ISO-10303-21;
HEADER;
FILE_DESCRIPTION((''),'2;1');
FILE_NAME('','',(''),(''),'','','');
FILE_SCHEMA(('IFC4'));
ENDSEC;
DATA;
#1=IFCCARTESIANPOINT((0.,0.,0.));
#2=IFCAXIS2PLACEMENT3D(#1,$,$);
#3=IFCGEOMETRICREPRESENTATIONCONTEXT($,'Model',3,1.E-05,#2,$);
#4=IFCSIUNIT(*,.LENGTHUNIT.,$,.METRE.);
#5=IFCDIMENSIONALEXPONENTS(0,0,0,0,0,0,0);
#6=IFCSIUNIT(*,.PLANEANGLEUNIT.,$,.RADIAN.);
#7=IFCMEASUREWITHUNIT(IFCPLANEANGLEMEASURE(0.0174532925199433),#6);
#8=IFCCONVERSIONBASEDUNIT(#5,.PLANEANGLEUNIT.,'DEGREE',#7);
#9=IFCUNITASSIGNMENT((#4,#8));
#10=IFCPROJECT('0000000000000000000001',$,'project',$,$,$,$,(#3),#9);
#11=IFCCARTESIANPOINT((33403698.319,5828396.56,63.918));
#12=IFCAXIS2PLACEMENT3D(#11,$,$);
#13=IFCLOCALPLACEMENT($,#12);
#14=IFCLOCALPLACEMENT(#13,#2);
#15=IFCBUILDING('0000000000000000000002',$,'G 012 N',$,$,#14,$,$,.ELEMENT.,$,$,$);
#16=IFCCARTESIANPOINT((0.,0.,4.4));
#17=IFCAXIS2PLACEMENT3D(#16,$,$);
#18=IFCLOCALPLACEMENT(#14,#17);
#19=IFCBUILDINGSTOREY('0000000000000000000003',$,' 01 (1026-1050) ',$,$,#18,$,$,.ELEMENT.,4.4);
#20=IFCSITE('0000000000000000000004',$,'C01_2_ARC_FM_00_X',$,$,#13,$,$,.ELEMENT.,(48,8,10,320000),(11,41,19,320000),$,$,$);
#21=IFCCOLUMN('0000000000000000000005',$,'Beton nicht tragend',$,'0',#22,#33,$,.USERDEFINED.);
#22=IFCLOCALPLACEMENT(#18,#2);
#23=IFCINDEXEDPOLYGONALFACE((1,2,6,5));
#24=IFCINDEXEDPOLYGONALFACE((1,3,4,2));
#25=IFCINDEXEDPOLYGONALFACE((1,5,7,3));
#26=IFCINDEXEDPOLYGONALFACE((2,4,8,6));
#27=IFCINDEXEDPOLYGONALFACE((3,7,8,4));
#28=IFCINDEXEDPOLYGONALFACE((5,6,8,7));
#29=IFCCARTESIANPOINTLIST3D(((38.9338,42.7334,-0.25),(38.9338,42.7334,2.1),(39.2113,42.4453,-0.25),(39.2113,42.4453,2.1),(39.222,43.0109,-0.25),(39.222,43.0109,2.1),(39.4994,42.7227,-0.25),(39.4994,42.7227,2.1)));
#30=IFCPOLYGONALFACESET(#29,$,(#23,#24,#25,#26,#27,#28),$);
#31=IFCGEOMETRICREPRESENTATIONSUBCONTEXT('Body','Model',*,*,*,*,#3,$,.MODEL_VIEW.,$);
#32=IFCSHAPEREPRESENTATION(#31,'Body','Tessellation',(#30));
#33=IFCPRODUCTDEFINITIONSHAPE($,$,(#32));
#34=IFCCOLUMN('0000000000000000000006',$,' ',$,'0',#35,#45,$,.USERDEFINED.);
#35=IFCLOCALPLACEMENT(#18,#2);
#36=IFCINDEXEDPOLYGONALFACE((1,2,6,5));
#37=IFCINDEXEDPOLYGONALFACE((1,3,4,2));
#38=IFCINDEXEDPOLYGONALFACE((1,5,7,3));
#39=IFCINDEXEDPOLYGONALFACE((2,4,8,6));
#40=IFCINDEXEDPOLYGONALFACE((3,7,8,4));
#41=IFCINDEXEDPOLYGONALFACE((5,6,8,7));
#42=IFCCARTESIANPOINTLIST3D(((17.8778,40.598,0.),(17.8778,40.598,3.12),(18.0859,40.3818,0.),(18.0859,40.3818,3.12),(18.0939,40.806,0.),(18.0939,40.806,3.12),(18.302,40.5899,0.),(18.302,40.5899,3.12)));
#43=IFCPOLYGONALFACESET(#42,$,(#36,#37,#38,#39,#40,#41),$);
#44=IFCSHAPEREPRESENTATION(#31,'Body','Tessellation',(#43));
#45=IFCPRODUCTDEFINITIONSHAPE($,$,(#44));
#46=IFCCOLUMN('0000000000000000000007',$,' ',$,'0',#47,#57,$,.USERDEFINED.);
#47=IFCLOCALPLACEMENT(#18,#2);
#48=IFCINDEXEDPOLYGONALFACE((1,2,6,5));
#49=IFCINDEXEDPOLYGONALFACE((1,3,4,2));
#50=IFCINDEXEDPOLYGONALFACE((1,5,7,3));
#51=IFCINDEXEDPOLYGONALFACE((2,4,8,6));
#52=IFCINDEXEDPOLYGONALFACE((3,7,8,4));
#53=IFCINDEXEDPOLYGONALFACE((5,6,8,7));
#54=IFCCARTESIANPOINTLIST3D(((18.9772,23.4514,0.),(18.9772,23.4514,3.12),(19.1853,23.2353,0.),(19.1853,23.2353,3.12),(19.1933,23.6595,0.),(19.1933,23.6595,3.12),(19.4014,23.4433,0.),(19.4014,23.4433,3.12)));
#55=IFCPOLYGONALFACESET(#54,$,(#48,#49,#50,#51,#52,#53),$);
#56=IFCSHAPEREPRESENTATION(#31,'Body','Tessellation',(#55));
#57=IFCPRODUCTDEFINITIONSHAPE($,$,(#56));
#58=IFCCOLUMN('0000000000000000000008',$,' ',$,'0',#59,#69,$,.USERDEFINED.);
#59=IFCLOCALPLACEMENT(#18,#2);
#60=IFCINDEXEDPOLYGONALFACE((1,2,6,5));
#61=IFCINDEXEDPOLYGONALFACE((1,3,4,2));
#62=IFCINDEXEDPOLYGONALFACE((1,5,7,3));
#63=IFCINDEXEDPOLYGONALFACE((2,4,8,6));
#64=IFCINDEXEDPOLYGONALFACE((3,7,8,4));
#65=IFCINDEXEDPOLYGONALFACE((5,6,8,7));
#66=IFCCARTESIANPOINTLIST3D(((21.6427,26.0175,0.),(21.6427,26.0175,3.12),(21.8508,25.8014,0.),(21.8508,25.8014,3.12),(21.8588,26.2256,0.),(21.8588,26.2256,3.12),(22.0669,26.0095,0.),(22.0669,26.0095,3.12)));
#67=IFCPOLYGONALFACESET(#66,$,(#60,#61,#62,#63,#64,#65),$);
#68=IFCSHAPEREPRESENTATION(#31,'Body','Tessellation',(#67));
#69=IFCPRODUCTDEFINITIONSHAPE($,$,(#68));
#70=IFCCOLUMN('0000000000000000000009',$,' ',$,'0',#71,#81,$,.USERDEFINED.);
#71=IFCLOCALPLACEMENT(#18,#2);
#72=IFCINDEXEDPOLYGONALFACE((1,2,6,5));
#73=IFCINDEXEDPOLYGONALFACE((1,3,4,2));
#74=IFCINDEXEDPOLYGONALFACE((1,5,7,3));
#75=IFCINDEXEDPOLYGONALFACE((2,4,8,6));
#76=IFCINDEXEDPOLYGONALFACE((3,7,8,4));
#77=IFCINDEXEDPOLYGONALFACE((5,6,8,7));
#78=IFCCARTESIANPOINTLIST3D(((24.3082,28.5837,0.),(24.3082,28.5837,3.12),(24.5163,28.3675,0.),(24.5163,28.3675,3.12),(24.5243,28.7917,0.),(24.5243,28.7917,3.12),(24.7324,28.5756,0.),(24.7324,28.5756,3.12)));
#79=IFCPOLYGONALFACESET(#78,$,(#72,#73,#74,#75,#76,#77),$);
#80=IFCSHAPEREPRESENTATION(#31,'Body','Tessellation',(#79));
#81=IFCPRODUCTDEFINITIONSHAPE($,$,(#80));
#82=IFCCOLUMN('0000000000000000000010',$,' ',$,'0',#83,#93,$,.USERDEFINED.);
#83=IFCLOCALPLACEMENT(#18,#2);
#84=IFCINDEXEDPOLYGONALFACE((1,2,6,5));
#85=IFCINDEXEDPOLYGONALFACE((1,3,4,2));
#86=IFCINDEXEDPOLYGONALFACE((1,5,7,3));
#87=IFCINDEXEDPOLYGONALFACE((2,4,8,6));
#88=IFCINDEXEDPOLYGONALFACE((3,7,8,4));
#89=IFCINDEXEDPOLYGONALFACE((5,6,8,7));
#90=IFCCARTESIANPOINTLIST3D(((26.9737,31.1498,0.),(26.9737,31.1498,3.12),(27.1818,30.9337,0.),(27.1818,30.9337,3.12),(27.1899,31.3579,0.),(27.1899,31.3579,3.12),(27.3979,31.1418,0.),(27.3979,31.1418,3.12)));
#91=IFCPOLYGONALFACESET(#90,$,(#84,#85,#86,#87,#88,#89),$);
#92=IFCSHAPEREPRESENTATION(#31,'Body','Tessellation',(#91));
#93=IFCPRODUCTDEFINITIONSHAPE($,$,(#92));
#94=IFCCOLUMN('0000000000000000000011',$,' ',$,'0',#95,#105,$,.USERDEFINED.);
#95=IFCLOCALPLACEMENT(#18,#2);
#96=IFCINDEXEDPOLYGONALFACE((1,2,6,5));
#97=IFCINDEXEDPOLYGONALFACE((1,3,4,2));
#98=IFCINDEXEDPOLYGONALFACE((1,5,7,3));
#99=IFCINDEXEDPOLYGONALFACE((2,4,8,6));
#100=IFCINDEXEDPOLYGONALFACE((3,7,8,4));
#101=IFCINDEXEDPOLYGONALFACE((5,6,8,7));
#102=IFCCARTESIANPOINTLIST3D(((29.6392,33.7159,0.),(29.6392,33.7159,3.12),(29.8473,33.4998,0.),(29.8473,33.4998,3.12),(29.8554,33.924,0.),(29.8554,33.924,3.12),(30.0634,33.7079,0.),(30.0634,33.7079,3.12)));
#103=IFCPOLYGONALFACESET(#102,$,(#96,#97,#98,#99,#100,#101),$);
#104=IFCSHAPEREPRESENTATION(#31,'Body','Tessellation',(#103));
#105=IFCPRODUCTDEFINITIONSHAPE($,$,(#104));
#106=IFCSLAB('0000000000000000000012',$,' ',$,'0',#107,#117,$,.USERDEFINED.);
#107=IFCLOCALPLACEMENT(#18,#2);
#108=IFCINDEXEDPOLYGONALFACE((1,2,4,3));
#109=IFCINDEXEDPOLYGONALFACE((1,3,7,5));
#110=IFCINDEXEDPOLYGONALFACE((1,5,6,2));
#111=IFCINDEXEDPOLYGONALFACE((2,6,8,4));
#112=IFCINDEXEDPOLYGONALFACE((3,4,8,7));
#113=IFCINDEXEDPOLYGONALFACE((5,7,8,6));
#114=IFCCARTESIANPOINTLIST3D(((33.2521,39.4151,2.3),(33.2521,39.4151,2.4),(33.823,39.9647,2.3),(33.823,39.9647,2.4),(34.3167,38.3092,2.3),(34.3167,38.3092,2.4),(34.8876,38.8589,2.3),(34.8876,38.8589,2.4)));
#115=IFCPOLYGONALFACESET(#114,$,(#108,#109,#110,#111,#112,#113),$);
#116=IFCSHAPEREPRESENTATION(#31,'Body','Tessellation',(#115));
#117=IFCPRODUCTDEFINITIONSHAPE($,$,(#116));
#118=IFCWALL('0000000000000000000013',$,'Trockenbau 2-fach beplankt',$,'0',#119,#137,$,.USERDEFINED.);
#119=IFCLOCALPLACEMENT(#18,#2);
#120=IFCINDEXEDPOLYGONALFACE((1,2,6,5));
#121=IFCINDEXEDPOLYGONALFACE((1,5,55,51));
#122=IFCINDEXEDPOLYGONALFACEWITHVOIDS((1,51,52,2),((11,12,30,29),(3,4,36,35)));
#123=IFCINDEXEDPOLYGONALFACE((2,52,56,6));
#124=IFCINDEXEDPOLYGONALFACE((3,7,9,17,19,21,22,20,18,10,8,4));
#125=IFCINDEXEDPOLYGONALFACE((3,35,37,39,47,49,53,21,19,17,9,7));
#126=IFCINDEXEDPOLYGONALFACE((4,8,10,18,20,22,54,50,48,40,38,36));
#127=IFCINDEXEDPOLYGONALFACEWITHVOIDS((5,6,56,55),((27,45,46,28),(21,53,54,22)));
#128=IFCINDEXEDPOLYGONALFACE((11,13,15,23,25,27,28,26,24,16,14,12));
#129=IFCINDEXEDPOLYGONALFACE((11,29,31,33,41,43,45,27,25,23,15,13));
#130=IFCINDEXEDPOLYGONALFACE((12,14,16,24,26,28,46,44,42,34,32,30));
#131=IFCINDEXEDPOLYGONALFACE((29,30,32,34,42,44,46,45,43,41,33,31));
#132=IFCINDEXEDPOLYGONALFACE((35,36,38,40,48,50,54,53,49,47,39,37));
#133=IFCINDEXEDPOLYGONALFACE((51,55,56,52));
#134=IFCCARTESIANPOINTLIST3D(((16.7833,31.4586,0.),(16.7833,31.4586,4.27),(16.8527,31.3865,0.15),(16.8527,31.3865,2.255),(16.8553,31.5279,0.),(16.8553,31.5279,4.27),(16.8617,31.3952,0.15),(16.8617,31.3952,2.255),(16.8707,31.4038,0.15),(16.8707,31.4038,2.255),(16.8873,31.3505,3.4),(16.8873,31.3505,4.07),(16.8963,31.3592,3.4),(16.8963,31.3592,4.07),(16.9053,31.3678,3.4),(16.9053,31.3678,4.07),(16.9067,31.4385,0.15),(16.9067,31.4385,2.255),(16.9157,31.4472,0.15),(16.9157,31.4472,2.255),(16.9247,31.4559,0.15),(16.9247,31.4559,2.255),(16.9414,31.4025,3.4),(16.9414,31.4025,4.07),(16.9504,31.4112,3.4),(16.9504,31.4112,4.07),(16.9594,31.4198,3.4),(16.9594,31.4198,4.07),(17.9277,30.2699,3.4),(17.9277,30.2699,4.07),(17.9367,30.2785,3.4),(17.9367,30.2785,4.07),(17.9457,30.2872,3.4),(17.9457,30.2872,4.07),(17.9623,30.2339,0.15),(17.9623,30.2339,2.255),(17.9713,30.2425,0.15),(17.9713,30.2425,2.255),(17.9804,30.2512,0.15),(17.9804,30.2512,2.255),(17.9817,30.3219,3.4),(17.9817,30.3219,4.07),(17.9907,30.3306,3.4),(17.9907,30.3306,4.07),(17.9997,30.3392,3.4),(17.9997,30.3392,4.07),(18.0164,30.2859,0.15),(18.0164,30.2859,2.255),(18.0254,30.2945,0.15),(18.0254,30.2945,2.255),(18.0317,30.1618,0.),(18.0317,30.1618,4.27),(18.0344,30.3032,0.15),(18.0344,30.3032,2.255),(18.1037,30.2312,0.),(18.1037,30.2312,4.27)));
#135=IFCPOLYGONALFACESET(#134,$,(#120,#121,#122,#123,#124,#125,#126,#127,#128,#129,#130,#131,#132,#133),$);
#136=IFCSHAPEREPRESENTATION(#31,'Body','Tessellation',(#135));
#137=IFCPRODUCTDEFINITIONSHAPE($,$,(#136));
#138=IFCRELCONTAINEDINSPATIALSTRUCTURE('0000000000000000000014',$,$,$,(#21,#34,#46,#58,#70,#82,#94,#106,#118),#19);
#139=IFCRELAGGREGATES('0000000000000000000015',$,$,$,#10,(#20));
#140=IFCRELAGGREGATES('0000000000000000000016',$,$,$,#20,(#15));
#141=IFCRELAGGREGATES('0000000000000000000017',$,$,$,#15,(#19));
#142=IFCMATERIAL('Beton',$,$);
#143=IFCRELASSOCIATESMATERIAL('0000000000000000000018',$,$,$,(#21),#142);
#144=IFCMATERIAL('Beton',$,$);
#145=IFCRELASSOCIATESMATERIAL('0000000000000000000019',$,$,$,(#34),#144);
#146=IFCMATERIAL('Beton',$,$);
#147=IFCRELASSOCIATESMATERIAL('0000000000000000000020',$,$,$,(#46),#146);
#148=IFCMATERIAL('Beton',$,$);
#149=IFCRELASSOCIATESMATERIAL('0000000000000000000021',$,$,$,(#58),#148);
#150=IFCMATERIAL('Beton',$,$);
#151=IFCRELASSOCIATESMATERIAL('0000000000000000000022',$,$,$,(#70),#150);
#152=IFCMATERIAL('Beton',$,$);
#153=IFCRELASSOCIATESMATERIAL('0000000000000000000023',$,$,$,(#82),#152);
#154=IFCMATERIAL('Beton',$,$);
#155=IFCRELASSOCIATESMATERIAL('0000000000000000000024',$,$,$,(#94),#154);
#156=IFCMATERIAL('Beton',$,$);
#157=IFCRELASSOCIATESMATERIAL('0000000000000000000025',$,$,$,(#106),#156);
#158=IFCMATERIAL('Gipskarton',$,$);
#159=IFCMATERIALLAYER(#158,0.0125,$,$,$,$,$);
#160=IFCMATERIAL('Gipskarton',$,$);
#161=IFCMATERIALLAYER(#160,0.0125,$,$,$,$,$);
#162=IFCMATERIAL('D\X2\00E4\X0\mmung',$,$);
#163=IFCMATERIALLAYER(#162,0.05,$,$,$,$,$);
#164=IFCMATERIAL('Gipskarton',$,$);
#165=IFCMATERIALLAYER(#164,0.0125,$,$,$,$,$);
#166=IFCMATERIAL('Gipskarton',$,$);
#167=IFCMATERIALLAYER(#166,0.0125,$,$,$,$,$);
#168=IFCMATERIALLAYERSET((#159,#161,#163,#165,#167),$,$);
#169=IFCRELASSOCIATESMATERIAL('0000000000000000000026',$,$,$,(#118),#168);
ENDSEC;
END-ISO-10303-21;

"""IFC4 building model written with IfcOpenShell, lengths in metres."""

from ifc_helpers import new_model, entity, si_unit, converted_unit, frame, frame_2d, origin, origin_with_axes, place, context, subcontext, project, spatial, polyline, rectangle, outline, extrude, material, layer, layer_set, layer_usage, element, save


model = new_model("IFC4")

# Units and contexts
model_context = context("Model", 3, precision=1e-05, world=origin())
body_context = subcontext(model_context, "Body", "Model", "MODEL_VIEW")
ifc_project = project(units=[si_unit("LENGTHUNIT", "METRE"), converted_unit("PLANEANGLEUNIT", "DEGREE", entity("IfcPlaneAngleMeasure", 0.0174532925199433), si_unit("PLANEANGLEUNIT", "RADIAN"), dimensions=[0, 0, 0, 0, 0, 0, 0])], contexts=[model_context])

# Site, building, storey
site_placement = place(None, frame((33403698.319, 5828396.56, 63.918)))
site = spatial("IfcSite", under=ifc_project, at=site_placement, Name="C01_2_ARC_FM_00_X", CompositionType="ELEMENT", RefLatitude=(48, 8, 10, 320000), RefLongitude=(11, 41, 19, 320000))
building_placement = place(site_placement, origin())
building = spatial("IfcBuilding", under=site, at=building_placement, Name="G 012 N", CompositionType="ELEMENT")
storey_placement = place(building_placement, frame((0.0, 0.0, 4.4)))
storey = spatial("IfcBuildingStorey", under=building, at=storey_placement, Name=" 01 (1026-1050) ", CompositionType="ELEMENT", Elevation=4.4)

# Columns
ifc_material_1 = material(Name="Beton")
column_1_placement = place(storey_placement, frame((39.2113, 42.4453, -0.25)))
element("IfcColumn", 1, at=column_1_placement, inside=storey, material=ifc_material_1, Name="Beton nicht tragend", ObjectType="0", PredefinedType="USERDEFINED", context=body_context, shape_type="SweptSolid", body=[
    extrude(rectangle(XDim=0.4, YDim=0.4, at=frame_2d((0.0054, 0.2828), x_axis=(0.720408, 0.693551))), origin_with_axes(), (0.0, 0.0, 1.0), 2.35),
])
ifc_material_2 = material(Name="Beton")
column_2_placement = place(storey_placement, frame((18.0859, 40.3818, 0.0)))
element("IfcColumn", 2, at=column_2_placement, inside=storey, material=ifc_material_2, Name=" ", ObjectType="0", PredefinedType="USERDEFINED", context=body_context, shape_type="SweptSolid", body=[
    extrude(rectangle(XDim=0.3, YDim=0.3, at=frame_2d((0.004, 0.2121), x_axis=(0.720408, 0.693551))), origin_with_axes(), (0.0, 0.0, 1.0), 3.12),
])
ifc_material_3 = material(Name="Beton")
column_3_placement = place(storey_placement, frame((19.1853, 23.2353, 0.0)))
element("IfcColumn", 3, at=column_3_placement, inside=storey, material=ifc_material_3, Name=" ", ObjectType="0", PredefinedType="USERDEFINED", context=body_context, shape_type="SweptSolid", body=[
    extrude(rectangle(XDim=0.3, YDim=0.3, at=frame_2d((0.004, 0.2121), x_axis=(0.720408, 0.693551))), origin_with_axes(), (0.0, 0.0, 1.0), 3.12),
])
ifc_material_4 = material(Name="Beton")
column_4_placement = place(storey_placement, frame((21.8508, 25.8014, 0.0)))
element("IfcColumn", 4, at=column_4_placement, inside=storey, material=ifc_material_4, Name=" ", ObjectType="0", PredefinedType="USERDEFINED", context=body_context, shape_type="SweptSolid", body=[
    extrude(rectangle(XDim=0.3, YDim=0.3, at=frame_2d((0.004, 0.2121), x_axis=(0.720408, 0.693551))), origin_with_axes(), (0.0, 0.0, 1.0), 3.12),
])
ifc_material_5 = material(Name="Beton")
column_5_placement = place(storey_placement, frame((24.5163, 28.3675, 0.0)))
element("IfcColumn", 5, at=column_5_placement, inside=storey, material=ifc_material_5, Name=" ", ObjectType="0", PredefinedType="USERDEFINED", context=body_context, shape_type="SweptSolid", body=[
    extrude(rectangle(XDim=0.3, YDim=0.3, at=frame_2d((0.004, 0.2121), x_axis=(0.720408, 0.693551))), origin_with_axes(), (0.0, 0.0, 1.0), 3.12),
])
ifc_material_6 = material(Name="Beton")
column_6_placement = place(storey_placement, frame((27.1818, 30.9337, 0.0)))
element("IfcColumn", 6, at=column_6_placement, inside=storey, material=ifc_material_6, Name=" ", ObjectType="0", PredefinedType="USERDEFINED", context=body_context, shape_type="SweptSolid", body=[
    extrude(rectangle(XDim=0.3, YDim=0.3, at=frame_2d((0.004, 0.2121), x_axis=(0.720408, 0.693551))), origin_with_axes(), (0.0, 0.0, 1.0), 3.12),
])
ifc_material_7 = material(Name="Beton")
column_7_placement = place(storey_placement, frame((29.8473, 33.4998, 0.0)))
element("IfcColumn", 7, at=column_7_placement, inside=storey, material=ifc_material_7, Name=" ", ObjectType="0", PredefinedType="USERDEFINED", context=body_context, shape_type="SweptSolid", body=[
    extrude(rectangle(XDim=0.3, YDim=0.3, at=frame_2d((0.004, 0.2121), x_axis=(0.720408, 0.693551))), origin_with_axes(), (0.0, 0.0, 1.0), 3.12),
])

# Slab
ifc_material_8 = material(Name="Beton")
slab_placement = place(storey_placement, frame((33.2521, 38.3092, 2.3)))
element("IfcSlab", 8, at=slab_placement, inside=storey, material=ifc_material_8, Name=" ", ObjectType="0", PredefinedType="USERDEFINED", context=body_context, shape_type="SweptSolid", body=[
    extrude(rectangle(XDim=0.7925, YDim=1.535, at=frame_2d((0.2468, -0.8277), x_axis=(-0.720408, -0.693551))), frame((0.5709, 1.6555, 0.0), z_axis=(0.0, 0.0, 1.0), x_axis=(1.0, 0.0, 0.0)), (0.0, 0.0, 1.0), 0.1),
])

# Wall, openings
ifc_material_9 = material(Name="Gipskarton")
ifc_layer_1 = layer(ifc_material_9, 0.0125)
ifc_material_10 = material(Name="Gipskarton")
ifc_layer_2 = layer(ifc_material_10, 0.0125)
ifc_material_11 = material(Name="Dämmung")
ifc_layer_3 = layer(ifc_material_11, 0.05)
ifc_material_12 = material(Name="Gipskarton")
ifc_layer_4 = layer(ifc_material_12, 0.0125)
ifc_material_13 = material(Name="Gipskarton")
ifc_layer_5 = layer(ifc_material_13, 0.0125)
ifc_layer_set_1 = layer_set([ifc_layer_1, ifc_layer_2, ifc_layer_3, ifc_layer_4, ifc_layer_5])
ifc_layer_usage_1 = layer_usage(ifc_layer_set_1, "AXIS2", "POSITIVE", 0.0)
wall_1_placement = place(storey_placement, frame((18.1037, 30.2312, 0.0), z_axis=(0.0, 0.0, 1.0), x_axis=(-0.693551, 0.720408, 0.0)))
wall_1 = element("IfcWall", 9, at=wall_1_placement, inside=storey, material=ifc_layer_usage_1, Name="Trockenbau 2-fach beplankt", ObjectType="0", PredefinedType="USERDEFINED", context=body_context, shape_type="SweptSolid", body=[
    extrude(rectangle(XDim=1.8, YDim=0.1, at=frame_2d((0.9, 0.05), x_axis=(1.0, 0.0))), origin_with_axes(), (0.0, 0.0, 1.0), 4.27),
])
opening_1_placement = place(wall_1_placement, frame((0.1, 0.0, 0.15), z_axis=(0.0, 1.0, 0.0), x_axis=(0.0, 0.0, 1.0)))
element("IfcOpeningElement", 10, at=opening_1_placement, cuts=wall_1, ObjectType="0", PredefinedType="USERDEFINED", context=body_context, shape_type="SweptSolid", body=[
    extrude(outline(polyline([(0.0, 1.6), (2.105, 1.6), (2.105, 0.0), (0.0, 0.0), (0.0, 1.6)])), origin_with_axes(), (0.0, 0.0, 1.0), 0.0125),
    extrude(outline(polyline([(0.0, 1.6), (2.105, 1.6), (2.105, 0.0), (0.0, 0.0), (0.0, 1.6)])), frame((0.0, 0.0, 0.0125), z_axis=(0.0, 0.0, 1.0), x_axis=(1.0, 0.0, 0.0)), (0.0, 0.0, 1.0), 0.0125),
    extrude(outline(polyline([(0.0, 1.6), (2.105, 1.6), (2.105, 0.0), (0.0, 0.0), (0.0, 1.6)])), frame((0.0, 0.0, 0.025), z_axis=(0.0, 0.0, 1.0), x_axis=(1.0, 0.0, 0.0)), (0.0, 0.0, 1.0), 0.05),
    extrude(outline(polyline([(0.0, 1.6), (2.105, 1.6), (2.105, 0.0), (0.0, 0.0), (0.0, 1.6)])), frame((0.0, 0.0, 0.075), z_axis=(0.0, 0.0, 1.0), x_axis=(1.0, 0.0, 0.0)), (0.0, 0.0, 1.0), 0.0125),
    extrude(outline(polyline([(0.0, 1.6), (2.105, 1.6), (2.105, 0.0), (0.0, 0.0), (0.0, 1.6)])), frame((0.0, 0.0, 0.0875), z_axis=(0.0, 0.0, 1.0), x_axis=(1.0, 0.0, 0.0)), (0.0, 0.0, 1.0), 0.0125),
])
opening_2_placement = place(wall_1_placement, frame((0.15, 0.0, 3.4), z_axis=(0.0, 1.0, 0.0), x_axis=(0.0, 0.0, 1.0)))
element("IfcOpeningElement", 11, at=opening_2_placement, cuts=wall_1, ObjectType="0", PredefinedType="USERDEFINED", context=body_context, shape_type="SweptSolid", body=[
    extrude(outline(polyline([(0.0, 1.5), (0.67, 1.5), (0.67, 0.0), (0.0, 0.0), (0.0, 1.5)])), origin_with_axes(), (0.0, 0.0, 1.0), 0.0125),
    extrude(outline(polyline([(0.0, 1.5), (0.67, 1.5), (0.67, 0.0), (0.0, 0.0), (0.0, 1.5)])), frame((0.0, 0.0, 0.0125), z_axis=(0.0, 0.0, 1.0), x_axis=(1.0, 0.0, 0.0)), (0.0, 0.0, 1.0), 0.0125),
    extrude(outline(polyline([(0.0, 1.5), (0.67, 1.5), (0.67, 0.0), (0.0, 0.0), (0.0, 1.5)])), frame((0.0, 0.0, 0.025), z_axis=(0.0, 0.0, 1.0), x_axis=(1.0, 0.0, 0.0)), (0.0, 0.0, 1.0), 0.05),
    extrude(outline(polyline([(0.0, 1.5), (0.67, 1.5), (0.67, 0.0), (0.0, 0.0), (0.0, 1.5)])), frame((0.0, 0.0, 0.075), z_axis=(0.0, 0.0, 1.0), x_axis=(1.0, 0.0, 0.0)), (0.0, 0.0, 1.0), 0.0125),
    extrude(outline(polyline([(0.0, 1.5), (0.67, 1.5), (0.67, 0.0), (0.0, 0.0), (0.0, 1.5)])), frame((0.0, 0.0, 0.0875), z_axis=(0.0, 0.0, 1.0), x_axis=(1.0, 0.0, 0.0)), (0.0, 0.0, 1.0), 0.0125),
])

save(model, "model.ifc")
